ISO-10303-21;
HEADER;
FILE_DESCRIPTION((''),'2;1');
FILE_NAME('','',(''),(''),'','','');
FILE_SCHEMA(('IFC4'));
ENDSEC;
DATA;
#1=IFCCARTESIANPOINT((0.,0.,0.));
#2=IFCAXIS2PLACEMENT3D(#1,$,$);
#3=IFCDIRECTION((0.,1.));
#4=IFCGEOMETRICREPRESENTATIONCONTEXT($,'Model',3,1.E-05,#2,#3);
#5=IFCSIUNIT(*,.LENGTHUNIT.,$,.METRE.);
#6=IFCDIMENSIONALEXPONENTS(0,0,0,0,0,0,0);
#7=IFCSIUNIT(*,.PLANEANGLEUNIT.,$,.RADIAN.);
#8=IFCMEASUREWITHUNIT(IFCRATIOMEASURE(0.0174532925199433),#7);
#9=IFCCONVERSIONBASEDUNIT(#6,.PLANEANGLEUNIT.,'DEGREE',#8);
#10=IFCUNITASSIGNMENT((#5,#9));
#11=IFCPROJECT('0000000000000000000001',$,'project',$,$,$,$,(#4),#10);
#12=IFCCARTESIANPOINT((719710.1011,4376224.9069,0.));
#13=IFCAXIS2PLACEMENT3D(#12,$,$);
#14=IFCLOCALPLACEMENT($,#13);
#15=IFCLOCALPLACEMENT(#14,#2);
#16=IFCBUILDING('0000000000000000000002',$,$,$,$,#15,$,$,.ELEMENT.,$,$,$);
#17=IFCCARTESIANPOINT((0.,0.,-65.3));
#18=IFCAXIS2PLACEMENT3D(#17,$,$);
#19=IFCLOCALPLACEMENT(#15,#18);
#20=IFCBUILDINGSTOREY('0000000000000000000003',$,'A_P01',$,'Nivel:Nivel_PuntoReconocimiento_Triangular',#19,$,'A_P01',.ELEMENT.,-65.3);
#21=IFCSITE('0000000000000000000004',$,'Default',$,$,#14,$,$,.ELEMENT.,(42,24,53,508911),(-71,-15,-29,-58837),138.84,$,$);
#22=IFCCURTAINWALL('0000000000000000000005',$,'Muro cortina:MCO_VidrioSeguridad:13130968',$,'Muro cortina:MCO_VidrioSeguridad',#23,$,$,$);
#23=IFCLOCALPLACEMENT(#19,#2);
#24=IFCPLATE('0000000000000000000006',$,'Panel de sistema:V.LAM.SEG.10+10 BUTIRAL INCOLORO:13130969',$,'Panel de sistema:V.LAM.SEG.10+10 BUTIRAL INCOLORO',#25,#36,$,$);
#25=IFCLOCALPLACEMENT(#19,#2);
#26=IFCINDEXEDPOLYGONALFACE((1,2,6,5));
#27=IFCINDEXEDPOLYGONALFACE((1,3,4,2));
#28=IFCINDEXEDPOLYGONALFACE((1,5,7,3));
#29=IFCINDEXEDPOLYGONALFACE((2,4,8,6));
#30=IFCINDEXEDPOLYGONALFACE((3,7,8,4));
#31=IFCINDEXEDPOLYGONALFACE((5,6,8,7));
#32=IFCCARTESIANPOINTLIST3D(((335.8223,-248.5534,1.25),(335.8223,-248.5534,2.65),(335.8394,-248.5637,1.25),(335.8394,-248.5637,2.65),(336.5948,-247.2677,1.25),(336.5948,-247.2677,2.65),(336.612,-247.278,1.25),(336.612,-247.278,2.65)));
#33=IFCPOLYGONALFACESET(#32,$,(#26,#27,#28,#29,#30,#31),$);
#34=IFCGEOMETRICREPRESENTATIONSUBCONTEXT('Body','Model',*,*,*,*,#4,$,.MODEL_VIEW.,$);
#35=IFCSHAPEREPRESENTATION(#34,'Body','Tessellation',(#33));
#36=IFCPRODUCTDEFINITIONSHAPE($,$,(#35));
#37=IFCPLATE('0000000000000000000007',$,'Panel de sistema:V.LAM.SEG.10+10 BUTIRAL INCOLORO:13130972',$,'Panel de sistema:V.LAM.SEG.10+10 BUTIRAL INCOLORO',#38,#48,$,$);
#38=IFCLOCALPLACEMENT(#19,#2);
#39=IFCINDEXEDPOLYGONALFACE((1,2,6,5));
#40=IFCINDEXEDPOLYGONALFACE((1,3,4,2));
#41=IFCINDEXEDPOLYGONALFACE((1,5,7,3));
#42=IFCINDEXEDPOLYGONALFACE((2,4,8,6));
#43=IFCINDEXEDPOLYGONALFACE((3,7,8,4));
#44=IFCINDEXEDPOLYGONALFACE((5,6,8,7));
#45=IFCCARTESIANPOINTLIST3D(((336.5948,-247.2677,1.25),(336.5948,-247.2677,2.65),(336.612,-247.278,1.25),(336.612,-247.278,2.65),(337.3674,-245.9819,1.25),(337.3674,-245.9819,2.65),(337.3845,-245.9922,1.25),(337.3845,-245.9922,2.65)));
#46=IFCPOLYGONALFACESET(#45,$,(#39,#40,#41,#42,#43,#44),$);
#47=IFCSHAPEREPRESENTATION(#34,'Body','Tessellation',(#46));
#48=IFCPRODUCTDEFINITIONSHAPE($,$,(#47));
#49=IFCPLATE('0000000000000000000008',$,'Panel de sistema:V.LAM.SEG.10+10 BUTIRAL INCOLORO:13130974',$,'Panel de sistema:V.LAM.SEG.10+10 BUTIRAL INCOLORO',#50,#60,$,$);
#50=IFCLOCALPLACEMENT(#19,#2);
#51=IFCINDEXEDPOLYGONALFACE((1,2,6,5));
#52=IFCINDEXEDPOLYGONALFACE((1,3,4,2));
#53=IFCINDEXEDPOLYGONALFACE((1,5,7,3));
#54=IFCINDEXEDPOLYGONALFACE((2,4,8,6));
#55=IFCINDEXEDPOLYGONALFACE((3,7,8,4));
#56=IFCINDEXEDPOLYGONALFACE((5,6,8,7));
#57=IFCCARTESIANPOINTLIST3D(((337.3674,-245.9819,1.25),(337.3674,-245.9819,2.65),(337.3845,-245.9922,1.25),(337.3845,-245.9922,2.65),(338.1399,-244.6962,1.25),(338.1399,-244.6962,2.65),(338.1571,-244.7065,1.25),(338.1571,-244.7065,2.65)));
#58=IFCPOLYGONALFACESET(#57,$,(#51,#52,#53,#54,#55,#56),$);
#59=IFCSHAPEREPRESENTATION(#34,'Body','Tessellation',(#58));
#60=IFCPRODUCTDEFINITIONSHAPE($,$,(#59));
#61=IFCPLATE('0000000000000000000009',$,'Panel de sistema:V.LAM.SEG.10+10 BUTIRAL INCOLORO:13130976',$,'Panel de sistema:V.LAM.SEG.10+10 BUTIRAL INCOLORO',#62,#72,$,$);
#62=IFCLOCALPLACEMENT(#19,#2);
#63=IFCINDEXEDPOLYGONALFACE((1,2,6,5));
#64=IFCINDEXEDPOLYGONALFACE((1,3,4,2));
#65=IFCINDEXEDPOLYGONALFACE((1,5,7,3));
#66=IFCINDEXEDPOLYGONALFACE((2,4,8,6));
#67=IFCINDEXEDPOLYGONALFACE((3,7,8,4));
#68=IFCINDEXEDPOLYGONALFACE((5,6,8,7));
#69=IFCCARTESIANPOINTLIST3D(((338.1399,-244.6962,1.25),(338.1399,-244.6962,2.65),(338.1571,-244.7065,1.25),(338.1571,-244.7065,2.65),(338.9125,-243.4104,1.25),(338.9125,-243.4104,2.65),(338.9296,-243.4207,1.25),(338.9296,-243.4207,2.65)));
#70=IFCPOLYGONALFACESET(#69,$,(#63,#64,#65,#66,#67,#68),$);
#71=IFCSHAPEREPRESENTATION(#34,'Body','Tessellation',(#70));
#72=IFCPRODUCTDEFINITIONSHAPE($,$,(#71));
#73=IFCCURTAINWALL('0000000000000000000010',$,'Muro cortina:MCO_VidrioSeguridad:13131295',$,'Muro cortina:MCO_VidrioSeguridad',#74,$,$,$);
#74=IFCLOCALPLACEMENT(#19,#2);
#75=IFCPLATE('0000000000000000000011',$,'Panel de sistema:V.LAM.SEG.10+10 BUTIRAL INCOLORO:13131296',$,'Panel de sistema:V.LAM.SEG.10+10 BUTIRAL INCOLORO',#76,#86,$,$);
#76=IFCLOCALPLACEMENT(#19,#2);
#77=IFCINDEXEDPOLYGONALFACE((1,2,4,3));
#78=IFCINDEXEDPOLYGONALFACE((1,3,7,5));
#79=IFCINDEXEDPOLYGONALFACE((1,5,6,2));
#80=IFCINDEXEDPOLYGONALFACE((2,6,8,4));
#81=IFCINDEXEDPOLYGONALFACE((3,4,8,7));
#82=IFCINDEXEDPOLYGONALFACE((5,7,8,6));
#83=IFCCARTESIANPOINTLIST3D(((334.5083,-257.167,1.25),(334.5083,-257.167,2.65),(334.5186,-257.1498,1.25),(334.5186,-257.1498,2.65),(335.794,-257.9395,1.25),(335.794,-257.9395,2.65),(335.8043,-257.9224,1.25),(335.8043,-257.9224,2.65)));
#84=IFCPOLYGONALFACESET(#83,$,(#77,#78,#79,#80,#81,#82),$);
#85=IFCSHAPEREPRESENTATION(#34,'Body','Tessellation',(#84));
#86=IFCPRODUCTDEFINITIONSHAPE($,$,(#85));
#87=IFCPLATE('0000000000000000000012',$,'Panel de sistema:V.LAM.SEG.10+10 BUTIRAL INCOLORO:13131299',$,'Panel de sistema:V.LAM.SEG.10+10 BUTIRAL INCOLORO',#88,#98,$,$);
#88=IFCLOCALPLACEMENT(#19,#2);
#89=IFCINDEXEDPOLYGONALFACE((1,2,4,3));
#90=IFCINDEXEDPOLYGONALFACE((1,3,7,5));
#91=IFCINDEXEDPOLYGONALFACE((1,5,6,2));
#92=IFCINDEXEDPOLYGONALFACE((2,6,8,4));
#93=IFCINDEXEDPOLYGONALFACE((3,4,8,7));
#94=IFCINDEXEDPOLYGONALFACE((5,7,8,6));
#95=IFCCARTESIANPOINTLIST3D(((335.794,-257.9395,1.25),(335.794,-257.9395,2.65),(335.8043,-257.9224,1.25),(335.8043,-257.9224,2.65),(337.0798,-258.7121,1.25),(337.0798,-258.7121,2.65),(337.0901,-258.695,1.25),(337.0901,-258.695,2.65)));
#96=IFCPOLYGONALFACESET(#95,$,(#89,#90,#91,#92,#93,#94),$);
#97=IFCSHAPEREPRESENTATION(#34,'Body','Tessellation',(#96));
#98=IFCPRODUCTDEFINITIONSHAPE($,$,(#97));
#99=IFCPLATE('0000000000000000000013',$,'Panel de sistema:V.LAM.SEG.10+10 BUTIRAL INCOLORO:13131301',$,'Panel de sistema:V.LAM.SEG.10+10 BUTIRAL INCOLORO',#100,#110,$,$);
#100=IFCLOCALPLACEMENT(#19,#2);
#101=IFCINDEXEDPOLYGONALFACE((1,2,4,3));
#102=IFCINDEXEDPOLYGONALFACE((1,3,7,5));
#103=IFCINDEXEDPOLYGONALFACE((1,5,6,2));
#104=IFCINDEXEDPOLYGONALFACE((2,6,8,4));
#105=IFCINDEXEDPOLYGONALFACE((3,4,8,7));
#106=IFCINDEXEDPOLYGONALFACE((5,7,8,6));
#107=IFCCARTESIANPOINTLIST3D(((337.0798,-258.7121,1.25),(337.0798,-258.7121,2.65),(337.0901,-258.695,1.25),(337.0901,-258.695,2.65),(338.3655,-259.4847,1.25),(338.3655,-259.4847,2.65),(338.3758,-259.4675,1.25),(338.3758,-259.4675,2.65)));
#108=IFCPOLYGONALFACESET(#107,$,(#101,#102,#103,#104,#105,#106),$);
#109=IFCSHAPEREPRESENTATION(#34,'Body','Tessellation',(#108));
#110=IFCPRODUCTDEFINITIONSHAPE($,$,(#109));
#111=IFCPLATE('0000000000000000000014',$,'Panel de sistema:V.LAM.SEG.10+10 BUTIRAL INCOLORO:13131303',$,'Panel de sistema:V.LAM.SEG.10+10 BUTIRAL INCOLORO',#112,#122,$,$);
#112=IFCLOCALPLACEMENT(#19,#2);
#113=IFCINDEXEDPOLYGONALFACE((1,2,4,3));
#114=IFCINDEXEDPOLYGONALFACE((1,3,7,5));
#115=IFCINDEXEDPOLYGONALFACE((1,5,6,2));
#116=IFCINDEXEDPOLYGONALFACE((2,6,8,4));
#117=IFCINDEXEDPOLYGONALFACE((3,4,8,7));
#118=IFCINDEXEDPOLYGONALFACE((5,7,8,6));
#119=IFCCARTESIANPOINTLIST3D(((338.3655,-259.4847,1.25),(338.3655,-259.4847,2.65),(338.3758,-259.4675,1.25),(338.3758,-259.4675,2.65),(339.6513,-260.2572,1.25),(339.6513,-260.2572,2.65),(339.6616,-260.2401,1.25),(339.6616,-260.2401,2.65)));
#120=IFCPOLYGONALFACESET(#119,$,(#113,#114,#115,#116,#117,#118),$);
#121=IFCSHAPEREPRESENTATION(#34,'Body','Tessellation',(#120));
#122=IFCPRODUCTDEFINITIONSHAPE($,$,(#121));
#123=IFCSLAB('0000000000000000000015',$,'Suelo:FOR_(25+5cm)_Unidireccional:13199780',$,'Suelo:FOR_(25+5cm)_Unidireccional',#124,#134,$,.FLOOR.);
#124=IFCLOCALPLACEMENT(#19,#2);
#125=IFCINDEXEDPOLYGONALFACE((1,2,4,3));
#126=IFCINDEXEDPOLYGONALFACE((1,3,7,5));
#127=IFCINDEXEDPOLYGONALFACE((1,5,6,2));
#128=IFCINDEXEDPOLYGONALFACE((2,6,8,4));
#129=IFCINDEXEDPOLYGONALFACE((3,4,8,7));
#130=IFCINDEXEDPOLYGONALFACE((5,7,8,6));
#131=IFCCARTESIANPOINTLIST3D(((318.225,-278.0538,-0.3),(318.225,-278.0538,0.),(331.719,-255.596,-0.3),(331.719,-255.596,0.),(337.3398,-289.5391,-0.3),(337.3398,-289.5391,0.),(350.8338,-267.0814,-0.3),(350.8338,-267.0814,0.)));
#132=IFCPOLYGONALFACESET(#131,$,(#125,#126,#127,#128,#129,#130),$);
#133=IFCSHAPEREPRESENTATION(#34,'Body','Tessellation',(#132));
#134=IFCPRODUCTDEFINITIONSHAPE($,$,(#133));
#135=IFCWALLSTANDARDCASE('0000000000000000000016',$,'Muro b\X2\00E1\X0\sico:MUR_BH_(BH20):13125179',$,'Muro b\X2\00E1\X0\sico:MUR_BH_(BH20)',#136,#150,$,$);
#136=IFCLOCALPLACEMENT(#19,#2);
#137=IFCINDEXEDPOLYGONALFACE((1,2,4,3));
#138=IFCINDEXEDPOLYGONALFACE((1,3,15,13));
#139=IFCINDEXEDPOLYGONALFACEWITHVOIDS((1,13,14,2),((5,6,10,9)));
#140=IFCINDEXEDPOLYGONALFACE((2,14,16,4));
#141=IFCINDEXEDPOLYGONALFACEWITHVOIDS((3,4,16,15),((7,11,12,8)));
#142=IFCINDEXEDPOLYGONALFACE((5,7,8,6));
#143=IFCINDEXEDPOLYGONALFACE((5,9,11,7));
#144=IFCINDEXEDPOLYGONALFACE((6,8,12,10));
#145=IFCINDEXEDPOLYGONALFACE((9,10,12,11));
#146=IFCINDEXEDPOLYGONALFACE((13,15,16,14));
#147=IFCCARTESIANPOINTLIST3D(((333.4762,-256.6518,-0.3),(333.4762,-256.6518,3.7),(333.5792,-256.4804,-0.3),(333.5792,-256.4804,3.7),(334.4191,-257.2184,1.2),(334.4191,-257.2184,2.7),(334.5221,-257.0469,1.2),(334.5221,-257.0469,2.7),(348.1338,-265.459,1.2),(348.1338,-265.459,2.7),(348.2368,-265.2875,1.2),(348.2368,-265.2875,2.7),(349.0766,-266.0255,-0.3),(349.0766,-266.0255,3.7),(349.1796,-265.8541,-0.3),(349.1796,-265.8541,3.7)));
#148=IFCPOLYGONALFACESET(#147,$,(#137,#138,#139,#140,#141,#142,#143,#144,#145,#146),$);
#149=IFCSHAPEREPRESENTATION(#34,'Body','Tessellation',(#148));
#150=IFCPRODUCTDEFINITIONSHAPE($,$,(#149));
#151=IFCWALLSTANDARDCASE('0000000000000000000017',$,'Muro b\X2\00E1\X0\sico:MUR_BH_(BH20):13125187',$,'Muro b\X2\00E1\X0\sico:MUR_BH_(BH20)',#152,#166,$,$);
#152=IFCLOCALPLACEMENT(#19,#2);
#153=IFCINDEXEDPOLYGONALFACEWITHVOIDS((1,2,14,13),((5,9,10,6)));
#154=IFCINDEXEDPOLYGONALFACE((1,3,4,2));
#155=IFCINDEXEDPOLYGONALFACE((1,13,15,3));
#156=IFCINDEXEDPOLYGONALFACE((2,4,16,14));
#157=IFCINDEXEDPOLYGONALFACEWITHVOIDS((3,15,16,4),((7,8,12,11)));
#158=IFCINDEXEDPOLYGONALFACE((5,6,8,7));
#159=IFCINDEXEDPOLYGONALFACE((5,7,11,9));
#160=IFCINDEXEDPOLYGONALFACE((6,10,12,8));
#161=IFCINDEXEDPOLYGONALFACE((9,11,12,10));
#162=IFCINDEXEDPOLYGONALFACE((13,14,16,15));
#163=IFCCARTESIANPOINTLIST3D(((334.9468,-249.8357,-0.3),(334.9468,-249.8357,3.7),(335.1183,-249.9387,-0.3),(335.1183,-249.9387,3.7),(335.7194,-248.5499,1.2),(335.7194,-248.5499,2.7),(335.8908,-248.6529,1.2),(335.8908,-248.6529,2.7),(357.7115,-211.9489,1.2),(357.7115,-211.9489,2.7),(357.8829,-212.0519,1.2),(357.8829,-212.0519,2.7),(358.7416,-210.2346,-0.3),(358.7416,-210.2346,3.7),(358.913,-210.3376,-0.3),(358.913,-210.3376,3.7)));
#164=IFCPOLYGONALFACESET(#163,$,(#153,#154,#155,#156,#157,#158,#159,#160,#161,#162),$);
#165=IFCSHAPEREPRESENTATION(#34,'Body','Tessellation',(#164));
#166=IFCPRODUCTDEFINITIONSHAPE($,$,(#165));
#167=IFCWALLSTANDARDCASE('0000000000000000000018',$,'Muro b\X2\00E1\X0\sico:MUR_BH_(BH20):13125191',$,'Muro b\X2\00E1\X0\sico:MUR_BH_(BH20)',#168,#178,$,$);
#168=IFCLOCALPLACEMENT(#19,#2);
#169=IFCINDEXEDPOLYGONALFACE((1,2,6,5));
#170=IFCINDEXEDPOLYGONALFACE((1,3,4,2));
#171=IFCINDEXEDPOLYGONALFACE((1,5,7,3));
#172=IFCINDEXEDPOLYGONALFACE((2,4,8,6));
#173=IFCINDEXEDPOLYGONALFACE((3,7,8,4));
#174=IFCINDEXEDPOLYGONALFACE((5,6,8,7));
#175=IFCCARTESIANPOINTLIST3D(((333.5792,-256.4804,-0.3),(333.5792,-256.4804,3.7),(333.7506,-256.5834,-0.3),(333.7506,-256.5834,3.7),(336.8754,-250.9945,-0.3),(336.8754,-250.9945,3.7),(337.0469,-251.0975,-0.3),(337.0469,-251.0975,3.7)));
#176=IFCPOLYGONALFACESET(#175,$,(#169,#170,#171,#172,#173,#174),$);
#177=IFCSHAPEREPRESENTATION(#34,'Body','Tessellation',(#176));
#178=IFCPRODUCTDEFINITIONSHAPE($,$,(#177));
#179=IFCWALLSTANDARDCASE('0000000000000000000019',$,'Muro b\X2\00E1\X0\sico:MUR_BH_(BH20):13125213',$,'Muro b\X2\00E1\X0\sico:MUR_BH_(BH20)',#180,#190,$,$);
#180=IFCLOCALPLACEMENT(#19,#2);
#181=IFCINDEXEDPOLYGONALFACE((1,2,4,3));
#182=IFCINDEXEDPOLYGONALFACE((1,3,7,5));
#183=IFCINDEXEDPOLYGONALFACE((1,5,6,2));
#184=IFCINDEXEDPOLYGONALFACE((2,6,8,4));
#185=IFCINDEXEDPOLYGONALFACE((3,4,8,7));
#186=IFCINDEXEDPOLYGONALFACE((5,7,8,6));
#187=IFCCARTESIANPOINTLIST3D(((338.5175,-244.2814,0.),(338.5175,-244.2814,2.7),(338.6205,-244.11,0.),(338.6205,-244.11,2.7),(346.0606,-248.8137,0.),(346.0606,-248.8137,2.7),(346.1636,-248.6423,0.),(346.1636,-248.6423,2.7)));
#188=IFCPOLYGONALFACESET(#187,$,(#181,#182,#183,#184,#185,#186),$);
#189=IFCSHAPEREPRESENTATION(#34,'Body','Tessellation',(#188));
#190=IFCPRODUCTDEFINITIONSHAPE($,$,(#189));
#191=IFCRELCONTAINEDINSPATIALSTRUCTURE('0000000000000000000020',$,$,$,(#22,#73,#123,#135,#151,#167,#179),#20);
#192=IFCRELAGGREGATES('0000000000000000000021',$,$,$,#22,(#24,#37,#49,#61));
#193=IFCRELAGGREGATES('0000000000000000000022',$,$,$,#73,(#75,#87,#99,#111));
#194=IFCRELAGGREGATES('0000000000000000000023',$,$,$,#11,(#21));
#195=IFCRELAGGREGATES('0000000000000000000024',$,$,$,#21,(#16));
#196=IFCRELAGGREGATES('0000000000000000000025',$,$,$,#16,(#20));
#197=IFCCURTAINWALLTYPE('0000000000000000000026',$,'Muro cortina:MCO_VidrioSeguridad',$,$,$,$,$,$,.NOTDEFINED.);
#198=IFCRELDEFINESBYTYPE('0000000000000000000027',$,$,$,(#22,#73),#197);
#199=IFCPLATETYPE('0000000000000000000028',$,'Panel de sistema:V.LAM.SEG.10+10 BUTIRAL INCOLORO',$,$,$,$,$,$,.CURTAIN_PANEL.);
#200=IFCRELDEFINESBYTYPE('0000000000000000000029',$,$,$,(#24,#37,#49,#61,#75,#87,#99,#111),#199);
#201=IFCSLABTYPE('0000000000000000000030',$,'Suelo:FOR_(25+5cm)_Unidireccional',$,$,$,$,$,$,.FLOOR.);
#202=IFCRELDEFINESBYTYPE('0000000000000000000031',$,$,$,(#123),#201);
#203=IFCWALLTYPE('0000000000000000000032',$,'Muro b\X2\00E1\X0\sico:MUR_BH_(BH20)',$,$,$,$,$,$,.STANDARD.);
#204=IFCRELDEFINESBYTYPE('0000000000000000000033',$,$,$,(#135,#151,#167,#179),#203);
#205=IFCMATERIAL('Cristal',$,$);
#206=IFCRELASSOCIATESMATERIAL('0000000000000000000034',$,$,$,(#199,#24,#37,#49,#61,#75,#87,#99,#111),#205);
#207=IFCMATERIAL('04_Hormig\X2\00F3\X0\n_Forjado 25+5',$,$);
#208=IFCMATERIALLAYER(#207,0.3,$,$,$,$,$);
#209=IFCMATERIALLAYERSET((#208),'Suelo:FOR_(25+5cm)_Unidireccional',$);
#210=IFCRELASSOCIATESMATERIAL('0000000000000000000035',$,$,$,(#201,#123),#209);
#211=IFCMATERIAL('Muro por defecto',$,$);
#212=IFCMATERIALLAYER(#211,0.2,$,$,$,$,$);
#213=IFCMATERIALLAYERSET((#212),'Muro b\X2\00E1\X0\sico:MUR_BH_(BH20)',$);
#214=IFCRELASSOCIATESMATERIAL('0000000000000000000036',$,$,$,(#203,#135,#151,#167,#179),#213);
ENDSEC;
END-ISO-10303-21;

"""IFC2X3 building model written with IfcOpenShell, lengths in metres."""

from ifc_helpers import new_model, entity, si_unit, converted_unit, direction, frame, frame_2d, origin, origin_2d_with_axis, place, context, subcontext, project, spatial, rectangle, extrude, source, transform, mapped, material, layer, layer_set, layer_usage, type_object, type_shapes, element, aggregate, save


model = new_model("IFC2X3")

# Units and contexts
model_context = context("Model", 3, precision=1e-05, world=origin(), true_north=direction((0.0, 1.0)))
body_context = subcontext(model_context, "Body", "Model", "MODEL_VIEW")
ifc_project = project(units=[si_unit("LENGTHUNIT", "METRE"), converted_unit("PLANEANGLEUNIT", "DEGREE", entity("IfcRatioMeasure", 0.0174532925199433), si_unit("PLANEANGLEUNIT", "RADIAN"), dimensions=[0, 0, 0, 0, 0, 0, 0])], contexts=[model_context])

# Site, building, storey
site_placement = place(None, frame((719710.1011, 4376224.9069, 0.0)))
site = spatial("IfcSite", under=ifc_project, at=site_placement, Name="Default", CompositionType="ELEMENT", RefLatitude=(42, 24, 53, 508911), RefLongitude=(-71, -15, -29, -58837), RefElevation=138.84)
building_placement = place(site_placement, origin())
building = spatial("IfcBuilding", under=site, at=building_placement, CompositionType="ELEMENT")
storey_placement = place(building_placement, frame((0.0, 0.0, -65.3)))
storey = spatial("IfcBuildingStorey", under=building, at=storey_placement, Name="A_P01", ObjectType="Nivel:Nivel_PuntoReconocimiento_Triangular", LongName="A_P01", CompositionType="ELEMENT", Elevation=-65.3)

# Shared definitions
ifc_material_1 = material(Name="04_Hormigón_Forjado 25+5")
ifc_layer_1 = layer(ifc_material_1, 0.3)
ifc_layer_set_1 = layer_set([ifc_layer_1], Name="Suelo:FOR_(25+5cm)_Unidireccional")

# Curtain walls, plates
curtain_wall_type = type_object("IfcCurtainWallType", Name="Muro cortina:MCO_VidrioSeguridad", PredefinedType="NOTDEFINED")
curtain_wall_1_placement = place(storey_placement, frame((0.0, 0.0, 65.3)))
curtain_wall_1 = element("IfcCurtainWall", 1, at=curtain_wall_1_placement, inside=storey, type_object=curtain_wall_type, Name="Muro cortina:MCO_VidrioSeguridad:13130968", ObjectType="Muro cortina:MCO_VidrioSeguridad")
ifc_material_2 = material(Name="Cristal")
plate_type = type_object("IfcPlateType", Name="Panel de sistema:V.LAM.SEG.10+10 BUTIRAL INCOLORO", PredefinedType="CURTAIN_PANEL", material=ifc_material_2)
shared_shape = source(origin(), body_context, "Body", "SweptSolid", [
    extrude(rectangle(XDim=0.02, YDim=1.5, at=origin_2d_with_axis()), frame((0.0, 0.0, 0.0), z_axis=(0.0, 0.0, 1.0), x_axis=(0.0, 1.0, 0.0)), (0.0, 0.0, 1.0), 1.4),
])
type_shapes(plate_type, [shared_shape])
plate_1_placement = place(curtain_wall_1_placement, frame((336.2171, -247.9157, -64.05), z_axis=(0.0, 0.0, 1.0), x_axis=(0.515038, 0.857167, 0.0)))
plate_1 = element("IfcPlate", 2, at=plate_1_placement, type_object=plate_type, material=ifc_material_2, Name="Panel de sistema:V.LAM.SEG.10+10 BUTIRAL INCOLORO:13130969", ObjectType="Panel de sistema:V.LAM.SEG.10+10 BUTIRAL INCOLORO", context=body_context, shape_type="MappedRepresentation", body=[
    mapped(shared_shape, transform((0.0, 0.0, 0.0), scale=1.0)),
])
plate_2_placement = place(curtain_wall_1_placement, frame((336.9897, -246.63, -64.05), z_axis=(0.0, 0.0, 1.0), x_axis=(0.515038, 0.857167, 0.0)))
plate_2 = element("IfcPlate", 3, at=plate_2_placement, type_object=plate_type, material=ifc_material_2, Name="Panel de sistema:V.LAM.SEG.10+10 BUTIRAL INCOLORO:13130972", ObjectType="Panel de sistema:V.LAM.SEG.10+10 BUTIRAL INCOLORO", context=body_context, shape_type="MappedRepresentation", body=[
    mapped(shared_shape, transform((0.0, 0.0, 0.0), scale=1.0)),
])
plate_3_placement = place(curtain_wall_1_placement, frame((337.7622, -245.3442, -64.05), z_axis=(0.0, 0.0, 1.0), x_axis=(0.515038, 0.857167, 0.0)))
plate_3 = element("IfcPlate", 4, at=plate_3_placement, type_object=plate_type, material=ifc_material_2, Name="Panel de sistema:V.LAM.SEG.10+10 BUTIRAL INCOLORO:13130974", ObjectType="Panel de sistema:V.LAM.SEG.10+10 BUTIRAL INCOLORO", context=body_context, shape_type="MappedRepresentation", body=[
    mapped(shared_shape, transform((0.0, 0.0, 0.0), scale=1.0)),
])
plate_4_placement = place(curtain_wall_1_placement, frame((338.5348, -244.0585, -64.05), z_axis=(0.0, 0.0, 1.0), x_axis=(0.515038, 0.857167, 0.0)))
plate_4 = element("IfcPlate", 5, at=plate_4_placement, type_object=plate_type, material=ifc_material_2, Name="Panel de sistema:V.LAM.SEG.10+10 BUTIRAL INCOLORO:13130976", ObjectType="Panel de sistema:V.LAM.SEG.10+10 BUTIRAL INCOLORO", context=body_context, shape_type="MappedRepresentation", body=[
    mapped(shared_shape, transform((0.0, 0.0, 0.0), scale=1.0)),
])
aggregate(curtain_wall_1, [plate_1, plate_2, plate_3, plate_4])
curtain_wall_2_placement = place(storey_placement, frame((0.0, 0.0, 65.3)))
curtain_wall_2 = element("IfcCurtainWall", 6, at=curtain_wall_2_placement, inside=storey, type_object=curtain_wall_type, Name="Muro cortina:MCO_VidrioSeguridad:13131295", ObjectType="Muro cortina:MCO_VidrioSeguridad")
plate_5_placement = place(curtain_wall_2_placement, frame((335.1563, -257.5447, -64.05), z_axis=(0.0, 0.0, 1.0), x_axis=(0.857167, -0.515038, 0.0)))
plate_5 = element("IfcPlate", 7, at=plate_5_placement, type_object=plate_type, material=ifc_material_2, Name="Panel de sistema:V.LAM.SEG.10+10 BUTIRAL INCOLORO:13131296", ObjectType="Panel de sistema:V.LAM.SEG.10+10 BUTIRAL INCOLORO", context=body_context, shape_type="MappedRepresentation", body=[
    mapped(shared_shape, transform((0.0, 0.0, 0.0), scale=1.0)),
])
plate_6_placement = place(curtain_wall_2_placement, frame((336.4421, -258.3172, -64.05), z_axis=(0.0, 0.0, 1.0), x_axis=(0.857167, -0.515038, 0.0)))
plate_6 = element("IfcPlate", 8, at=plate_6_placement, type_object=plate_type, material=ifc_material_2, Name="Panel de sistema:V.LAM.SEG.10+10 BUTIRAL INCOLORO:13131299", ObjectType="Panel de sistema:V.LAM.SEG.10+10 BUTIRAL INCOLORO", context=body_context, shape_type="MappedRepresentation", body=[
    mapped(shared_shape, transform((0.0, 0.0, 0.0), scale=1.0)),
])
plate_7_placement = place(curtain_wall_2_placement, frame((337.7278, -259.0898, -64.05), z_axis=(0.0, 0.0, 1.0), x_axis=(0.857167, -0.515038, 0.0)))
plate_7 = element("IfcPlate", 9, at=plate_7_placement, type_object=plate_type, material=ifc_material_2, Name="Panel de sistema:V.LAM.SEG.10+10 BUTIRAL INCOLORO:13131301", ObjectType="Panel de sistema:V.LAM.SEG.10+10 BUTIRAL INCOLORO", context=body_context, shape_type="MappedRepresentation", body=[
    mapped(shared_shape, transform((0.0, 0.0, 0.0), scale=1.0)),
])
plate_8_placement = place(curtain_wall_2_placement, frame((339.0136, -259.8624, -64.05), z_axis=(0.0, 0.0, 1.0), x_axis=(0.857167, -0.515038, 0.0)))
plate_8 = element("IfcPlate", 10, at=plate_8_placement, type_object=plate_type, material=ifc_material_2, Name="Panel de sistema:V.LAM.SEG.10+10 BUTIRAL INCOLORO:13131303", ObjectType="Panel de sistema:V.LAM.SEG.10+10 BUTIRAL INCOLORO", context=body_context, shape_type="MappedRepresentation", body=[
    mapped(shared_shape, transform((0.0, 0.0, 0.0), scale=1.0)),
])
aggregate(curtain_wall_2, [plate_5, plate_6, plate_7, plate_8])

# Slab
ifc_layer_usage_1 = layer_usage(ifc_layer_set_1, "AXIS3", "POSITIVE", 0.0)
slab_type_1 = type_object("IfcSlabType", Name="Suelo:FOR_(25+5cm)_Unidireccional", PredefinedType="FLOOR", material=ifc_layer_set_1)
slab_1_placement = place(storey_placement, origin())
element("IfcSlab", 11, at=slab_1_placement, inside=storey, type_object=slab_type_1, material=ifc_layer_usage_1, Name="Suelo:FOR_(25+5cm)_Unidireccional:13199780", ObjectType="Suelo:FOR_(25+5cm)_Unidireccional", PredefinedType="FLOOR", context=body_context, shape_type="SweptSolid", body=[
    extrude(rectangle(XDim=22.3, YDim=26.2, at=frame_2d((0.0, 0.0), x_axis=(1.0, 0.0))), frame((334.5294, -272.5676, 0.0), z_axis=(0.0, 0.0, -1.0), x_axis=(0.857167, -0.515038, 0.0)), (0.0, 0.0, 1.0), 0.3),
])

# Walls, openings
ifc_material_3 = material(Name="Muro por defecto")
ifc_layer_2 = layer(ifc_material_3, 0.2)
ifc_layer_set_2 = layer_set([ifc_layer_2], Name="Muro básico:MUR_BH_(BH20)")
ifc_layer_usage_2 = layer_usage(ifc_layer_set_2, "AXIS2", "NEGATIVE", 0.1)
wall_type = type_object("IfcWallType", Name="Muro básico:MUR_BH_(BH20)", PredefinedType="STANDARD", material=ifc_layer_set_2)
wall_1_placement = place(storey_placement, frame((333.5277, -256.5661, -0.3), z_axis=(0.0, 0.0, 1.0), x_axis=(0.857167, -0.515038, 0.0)))
wall_1 = element("IfcWallStandardCase", 12, at=wall_1_placement, inside=storey, type_object=wall_type, material=ifc_layer_usage_2, Name="Muro básico:MUR_BH_(BH20):13125179", ObjectType="Muro básico:MUR_BH_(BH20)", context=body_context, shape_type="SweptSolid", body=[
    extrude(rectangle(XDim=18.2, YDim=0.2, at=frame_2d((9.1, 0.0), x_axis=(-1.0, 0.0))), origin(), (0.0, 0.0, 1.0), 4.0),
])
opening_1_placement = place(wall_1_placement, origin())
element("IfcOpeningElement", 13, at=opening_1_placement, cuts=wall_1, ObjectType="Opening", context=body_context, shape_type="SweptSolid", body=[
    extrude(rectangle(XDim=1.5, YDim=16.0, at=frame_2d((0.0, 0.0), x_axis=(1.0, 0.0))), frame((9.1, -0.2524, 2.25), z_axis=(0.0, 1.0, 0.0), x_axis=(0.0, 0.0, 1.0)), (0.0, 0.0, 1.0), 0.5048),
])
ifc_layer_usage_3 = layer_usage(ifc_layer_set_2, "AXIS2", "NEGATIVE", 0.1)
wall_2_placement = place(storey_placement, frame((335.0325, -249.8872, -0.3), z_axis=(0.0, 0.0, 1.0), x_axis=(0.515038, 0.857167, 0.0)))
wall_2 = element("IfcWallStandardCase", 14, at=wall_2_placement, inside=storey, type_object=wall_type, material=ifc_layer_usage_3, Name="Muro básico:MUR_BH_(BH20):13125187", ObjectType="Muro básico:MUR_BH_(BH20)", context=body_context, shape_type="SweptSolid", body=[
    extrude(rectangle(XDim=46.2, YDim=0.2, at=frame_2d((23.1, 0.0), x_axis=(-1.0, 0.0))), origin(), (0.0, 0.0, 1.0), 4.0),
])
opening_2_placement = place(wall_2_placement, origin())
element("IfcOpeningElement", 15, at=opening_2_placement, cuts=wall_2, ObjectType="Opening", context=body_context, shape_type="SweptSolid", body=[
    extrude(rectangle(XDim=1.5, YDim=42.7, at=frame_2d((0.0, 0.0), x_axis=(1.0, 0.0))), frame((22.85, -0.2524, 2.25), z_axis=(0.0, 1.0, 0.0), x_axis=(0.0, 0.0, 1.0)), (0.0, 0.0, 1.0), 0.5048),
])

# Walls
ifc_layer_usage_4 = layer_usage(ifc_layer_set_2, "AXIS2", "NEGATIVE", 0.1)
wall_3_placement = place(storey_placement, frame((333.6649, -256.5319, -0.3), z_axis=(0.0, 0.0, 1.0), x_axis=(0.515038, 0.857167, 0.0)))
element("IfcWallStandardCase", 16, at=wall_3_placement, inside=storey, type_object=wall_type, material=ifc_layer_usage_4, Name="Muro básico:MUR_BH_(BH20):13125191", ObjectType="Muro básico:MUR_BH_(BH20)", context=body_context, shape_type="SweptSolid", body=[
    extrude(rectangle(XDim=6.4, YDim=0.2, at=frame_2d((3.2, 0.0), x_axis=(-1.0, 0.0))), origin(), (0.0, 0.0, 1.0), 4.0),
])
ifc_layer_usage_5 = layer_usage(ifc_layer_set_2, "AXIS2", "NEGATIVE", 0.1)
wall_4_placement = place(storey_placement, frame((338.569, -244.1957, 0.0), z_axis=(0.0, 0.0, 1.0), x_axis=(0.857167, -0.515038, 0.0)))
element("IfcWallStandardCase", 17, at=wall_4_placement, inside=storey, type_object=wall_type, material=ifc_layer_usage_5, Name="Muro básico:MUR_BH_(BH20):13125213", ObjectType="Muro básico:MUR_BH_(BH20)", context=body_context, shape_type="SweptSolid", body=[
    extrude(rectangle(XDim=8.8, YDim=0.2, at=frame_2d((4.4, 0.0), x_axis=(-1.0, 0.0))), origin(), (0.0, 0.0, 1.0), 2.7),
])

save(model, "model.ifc")
